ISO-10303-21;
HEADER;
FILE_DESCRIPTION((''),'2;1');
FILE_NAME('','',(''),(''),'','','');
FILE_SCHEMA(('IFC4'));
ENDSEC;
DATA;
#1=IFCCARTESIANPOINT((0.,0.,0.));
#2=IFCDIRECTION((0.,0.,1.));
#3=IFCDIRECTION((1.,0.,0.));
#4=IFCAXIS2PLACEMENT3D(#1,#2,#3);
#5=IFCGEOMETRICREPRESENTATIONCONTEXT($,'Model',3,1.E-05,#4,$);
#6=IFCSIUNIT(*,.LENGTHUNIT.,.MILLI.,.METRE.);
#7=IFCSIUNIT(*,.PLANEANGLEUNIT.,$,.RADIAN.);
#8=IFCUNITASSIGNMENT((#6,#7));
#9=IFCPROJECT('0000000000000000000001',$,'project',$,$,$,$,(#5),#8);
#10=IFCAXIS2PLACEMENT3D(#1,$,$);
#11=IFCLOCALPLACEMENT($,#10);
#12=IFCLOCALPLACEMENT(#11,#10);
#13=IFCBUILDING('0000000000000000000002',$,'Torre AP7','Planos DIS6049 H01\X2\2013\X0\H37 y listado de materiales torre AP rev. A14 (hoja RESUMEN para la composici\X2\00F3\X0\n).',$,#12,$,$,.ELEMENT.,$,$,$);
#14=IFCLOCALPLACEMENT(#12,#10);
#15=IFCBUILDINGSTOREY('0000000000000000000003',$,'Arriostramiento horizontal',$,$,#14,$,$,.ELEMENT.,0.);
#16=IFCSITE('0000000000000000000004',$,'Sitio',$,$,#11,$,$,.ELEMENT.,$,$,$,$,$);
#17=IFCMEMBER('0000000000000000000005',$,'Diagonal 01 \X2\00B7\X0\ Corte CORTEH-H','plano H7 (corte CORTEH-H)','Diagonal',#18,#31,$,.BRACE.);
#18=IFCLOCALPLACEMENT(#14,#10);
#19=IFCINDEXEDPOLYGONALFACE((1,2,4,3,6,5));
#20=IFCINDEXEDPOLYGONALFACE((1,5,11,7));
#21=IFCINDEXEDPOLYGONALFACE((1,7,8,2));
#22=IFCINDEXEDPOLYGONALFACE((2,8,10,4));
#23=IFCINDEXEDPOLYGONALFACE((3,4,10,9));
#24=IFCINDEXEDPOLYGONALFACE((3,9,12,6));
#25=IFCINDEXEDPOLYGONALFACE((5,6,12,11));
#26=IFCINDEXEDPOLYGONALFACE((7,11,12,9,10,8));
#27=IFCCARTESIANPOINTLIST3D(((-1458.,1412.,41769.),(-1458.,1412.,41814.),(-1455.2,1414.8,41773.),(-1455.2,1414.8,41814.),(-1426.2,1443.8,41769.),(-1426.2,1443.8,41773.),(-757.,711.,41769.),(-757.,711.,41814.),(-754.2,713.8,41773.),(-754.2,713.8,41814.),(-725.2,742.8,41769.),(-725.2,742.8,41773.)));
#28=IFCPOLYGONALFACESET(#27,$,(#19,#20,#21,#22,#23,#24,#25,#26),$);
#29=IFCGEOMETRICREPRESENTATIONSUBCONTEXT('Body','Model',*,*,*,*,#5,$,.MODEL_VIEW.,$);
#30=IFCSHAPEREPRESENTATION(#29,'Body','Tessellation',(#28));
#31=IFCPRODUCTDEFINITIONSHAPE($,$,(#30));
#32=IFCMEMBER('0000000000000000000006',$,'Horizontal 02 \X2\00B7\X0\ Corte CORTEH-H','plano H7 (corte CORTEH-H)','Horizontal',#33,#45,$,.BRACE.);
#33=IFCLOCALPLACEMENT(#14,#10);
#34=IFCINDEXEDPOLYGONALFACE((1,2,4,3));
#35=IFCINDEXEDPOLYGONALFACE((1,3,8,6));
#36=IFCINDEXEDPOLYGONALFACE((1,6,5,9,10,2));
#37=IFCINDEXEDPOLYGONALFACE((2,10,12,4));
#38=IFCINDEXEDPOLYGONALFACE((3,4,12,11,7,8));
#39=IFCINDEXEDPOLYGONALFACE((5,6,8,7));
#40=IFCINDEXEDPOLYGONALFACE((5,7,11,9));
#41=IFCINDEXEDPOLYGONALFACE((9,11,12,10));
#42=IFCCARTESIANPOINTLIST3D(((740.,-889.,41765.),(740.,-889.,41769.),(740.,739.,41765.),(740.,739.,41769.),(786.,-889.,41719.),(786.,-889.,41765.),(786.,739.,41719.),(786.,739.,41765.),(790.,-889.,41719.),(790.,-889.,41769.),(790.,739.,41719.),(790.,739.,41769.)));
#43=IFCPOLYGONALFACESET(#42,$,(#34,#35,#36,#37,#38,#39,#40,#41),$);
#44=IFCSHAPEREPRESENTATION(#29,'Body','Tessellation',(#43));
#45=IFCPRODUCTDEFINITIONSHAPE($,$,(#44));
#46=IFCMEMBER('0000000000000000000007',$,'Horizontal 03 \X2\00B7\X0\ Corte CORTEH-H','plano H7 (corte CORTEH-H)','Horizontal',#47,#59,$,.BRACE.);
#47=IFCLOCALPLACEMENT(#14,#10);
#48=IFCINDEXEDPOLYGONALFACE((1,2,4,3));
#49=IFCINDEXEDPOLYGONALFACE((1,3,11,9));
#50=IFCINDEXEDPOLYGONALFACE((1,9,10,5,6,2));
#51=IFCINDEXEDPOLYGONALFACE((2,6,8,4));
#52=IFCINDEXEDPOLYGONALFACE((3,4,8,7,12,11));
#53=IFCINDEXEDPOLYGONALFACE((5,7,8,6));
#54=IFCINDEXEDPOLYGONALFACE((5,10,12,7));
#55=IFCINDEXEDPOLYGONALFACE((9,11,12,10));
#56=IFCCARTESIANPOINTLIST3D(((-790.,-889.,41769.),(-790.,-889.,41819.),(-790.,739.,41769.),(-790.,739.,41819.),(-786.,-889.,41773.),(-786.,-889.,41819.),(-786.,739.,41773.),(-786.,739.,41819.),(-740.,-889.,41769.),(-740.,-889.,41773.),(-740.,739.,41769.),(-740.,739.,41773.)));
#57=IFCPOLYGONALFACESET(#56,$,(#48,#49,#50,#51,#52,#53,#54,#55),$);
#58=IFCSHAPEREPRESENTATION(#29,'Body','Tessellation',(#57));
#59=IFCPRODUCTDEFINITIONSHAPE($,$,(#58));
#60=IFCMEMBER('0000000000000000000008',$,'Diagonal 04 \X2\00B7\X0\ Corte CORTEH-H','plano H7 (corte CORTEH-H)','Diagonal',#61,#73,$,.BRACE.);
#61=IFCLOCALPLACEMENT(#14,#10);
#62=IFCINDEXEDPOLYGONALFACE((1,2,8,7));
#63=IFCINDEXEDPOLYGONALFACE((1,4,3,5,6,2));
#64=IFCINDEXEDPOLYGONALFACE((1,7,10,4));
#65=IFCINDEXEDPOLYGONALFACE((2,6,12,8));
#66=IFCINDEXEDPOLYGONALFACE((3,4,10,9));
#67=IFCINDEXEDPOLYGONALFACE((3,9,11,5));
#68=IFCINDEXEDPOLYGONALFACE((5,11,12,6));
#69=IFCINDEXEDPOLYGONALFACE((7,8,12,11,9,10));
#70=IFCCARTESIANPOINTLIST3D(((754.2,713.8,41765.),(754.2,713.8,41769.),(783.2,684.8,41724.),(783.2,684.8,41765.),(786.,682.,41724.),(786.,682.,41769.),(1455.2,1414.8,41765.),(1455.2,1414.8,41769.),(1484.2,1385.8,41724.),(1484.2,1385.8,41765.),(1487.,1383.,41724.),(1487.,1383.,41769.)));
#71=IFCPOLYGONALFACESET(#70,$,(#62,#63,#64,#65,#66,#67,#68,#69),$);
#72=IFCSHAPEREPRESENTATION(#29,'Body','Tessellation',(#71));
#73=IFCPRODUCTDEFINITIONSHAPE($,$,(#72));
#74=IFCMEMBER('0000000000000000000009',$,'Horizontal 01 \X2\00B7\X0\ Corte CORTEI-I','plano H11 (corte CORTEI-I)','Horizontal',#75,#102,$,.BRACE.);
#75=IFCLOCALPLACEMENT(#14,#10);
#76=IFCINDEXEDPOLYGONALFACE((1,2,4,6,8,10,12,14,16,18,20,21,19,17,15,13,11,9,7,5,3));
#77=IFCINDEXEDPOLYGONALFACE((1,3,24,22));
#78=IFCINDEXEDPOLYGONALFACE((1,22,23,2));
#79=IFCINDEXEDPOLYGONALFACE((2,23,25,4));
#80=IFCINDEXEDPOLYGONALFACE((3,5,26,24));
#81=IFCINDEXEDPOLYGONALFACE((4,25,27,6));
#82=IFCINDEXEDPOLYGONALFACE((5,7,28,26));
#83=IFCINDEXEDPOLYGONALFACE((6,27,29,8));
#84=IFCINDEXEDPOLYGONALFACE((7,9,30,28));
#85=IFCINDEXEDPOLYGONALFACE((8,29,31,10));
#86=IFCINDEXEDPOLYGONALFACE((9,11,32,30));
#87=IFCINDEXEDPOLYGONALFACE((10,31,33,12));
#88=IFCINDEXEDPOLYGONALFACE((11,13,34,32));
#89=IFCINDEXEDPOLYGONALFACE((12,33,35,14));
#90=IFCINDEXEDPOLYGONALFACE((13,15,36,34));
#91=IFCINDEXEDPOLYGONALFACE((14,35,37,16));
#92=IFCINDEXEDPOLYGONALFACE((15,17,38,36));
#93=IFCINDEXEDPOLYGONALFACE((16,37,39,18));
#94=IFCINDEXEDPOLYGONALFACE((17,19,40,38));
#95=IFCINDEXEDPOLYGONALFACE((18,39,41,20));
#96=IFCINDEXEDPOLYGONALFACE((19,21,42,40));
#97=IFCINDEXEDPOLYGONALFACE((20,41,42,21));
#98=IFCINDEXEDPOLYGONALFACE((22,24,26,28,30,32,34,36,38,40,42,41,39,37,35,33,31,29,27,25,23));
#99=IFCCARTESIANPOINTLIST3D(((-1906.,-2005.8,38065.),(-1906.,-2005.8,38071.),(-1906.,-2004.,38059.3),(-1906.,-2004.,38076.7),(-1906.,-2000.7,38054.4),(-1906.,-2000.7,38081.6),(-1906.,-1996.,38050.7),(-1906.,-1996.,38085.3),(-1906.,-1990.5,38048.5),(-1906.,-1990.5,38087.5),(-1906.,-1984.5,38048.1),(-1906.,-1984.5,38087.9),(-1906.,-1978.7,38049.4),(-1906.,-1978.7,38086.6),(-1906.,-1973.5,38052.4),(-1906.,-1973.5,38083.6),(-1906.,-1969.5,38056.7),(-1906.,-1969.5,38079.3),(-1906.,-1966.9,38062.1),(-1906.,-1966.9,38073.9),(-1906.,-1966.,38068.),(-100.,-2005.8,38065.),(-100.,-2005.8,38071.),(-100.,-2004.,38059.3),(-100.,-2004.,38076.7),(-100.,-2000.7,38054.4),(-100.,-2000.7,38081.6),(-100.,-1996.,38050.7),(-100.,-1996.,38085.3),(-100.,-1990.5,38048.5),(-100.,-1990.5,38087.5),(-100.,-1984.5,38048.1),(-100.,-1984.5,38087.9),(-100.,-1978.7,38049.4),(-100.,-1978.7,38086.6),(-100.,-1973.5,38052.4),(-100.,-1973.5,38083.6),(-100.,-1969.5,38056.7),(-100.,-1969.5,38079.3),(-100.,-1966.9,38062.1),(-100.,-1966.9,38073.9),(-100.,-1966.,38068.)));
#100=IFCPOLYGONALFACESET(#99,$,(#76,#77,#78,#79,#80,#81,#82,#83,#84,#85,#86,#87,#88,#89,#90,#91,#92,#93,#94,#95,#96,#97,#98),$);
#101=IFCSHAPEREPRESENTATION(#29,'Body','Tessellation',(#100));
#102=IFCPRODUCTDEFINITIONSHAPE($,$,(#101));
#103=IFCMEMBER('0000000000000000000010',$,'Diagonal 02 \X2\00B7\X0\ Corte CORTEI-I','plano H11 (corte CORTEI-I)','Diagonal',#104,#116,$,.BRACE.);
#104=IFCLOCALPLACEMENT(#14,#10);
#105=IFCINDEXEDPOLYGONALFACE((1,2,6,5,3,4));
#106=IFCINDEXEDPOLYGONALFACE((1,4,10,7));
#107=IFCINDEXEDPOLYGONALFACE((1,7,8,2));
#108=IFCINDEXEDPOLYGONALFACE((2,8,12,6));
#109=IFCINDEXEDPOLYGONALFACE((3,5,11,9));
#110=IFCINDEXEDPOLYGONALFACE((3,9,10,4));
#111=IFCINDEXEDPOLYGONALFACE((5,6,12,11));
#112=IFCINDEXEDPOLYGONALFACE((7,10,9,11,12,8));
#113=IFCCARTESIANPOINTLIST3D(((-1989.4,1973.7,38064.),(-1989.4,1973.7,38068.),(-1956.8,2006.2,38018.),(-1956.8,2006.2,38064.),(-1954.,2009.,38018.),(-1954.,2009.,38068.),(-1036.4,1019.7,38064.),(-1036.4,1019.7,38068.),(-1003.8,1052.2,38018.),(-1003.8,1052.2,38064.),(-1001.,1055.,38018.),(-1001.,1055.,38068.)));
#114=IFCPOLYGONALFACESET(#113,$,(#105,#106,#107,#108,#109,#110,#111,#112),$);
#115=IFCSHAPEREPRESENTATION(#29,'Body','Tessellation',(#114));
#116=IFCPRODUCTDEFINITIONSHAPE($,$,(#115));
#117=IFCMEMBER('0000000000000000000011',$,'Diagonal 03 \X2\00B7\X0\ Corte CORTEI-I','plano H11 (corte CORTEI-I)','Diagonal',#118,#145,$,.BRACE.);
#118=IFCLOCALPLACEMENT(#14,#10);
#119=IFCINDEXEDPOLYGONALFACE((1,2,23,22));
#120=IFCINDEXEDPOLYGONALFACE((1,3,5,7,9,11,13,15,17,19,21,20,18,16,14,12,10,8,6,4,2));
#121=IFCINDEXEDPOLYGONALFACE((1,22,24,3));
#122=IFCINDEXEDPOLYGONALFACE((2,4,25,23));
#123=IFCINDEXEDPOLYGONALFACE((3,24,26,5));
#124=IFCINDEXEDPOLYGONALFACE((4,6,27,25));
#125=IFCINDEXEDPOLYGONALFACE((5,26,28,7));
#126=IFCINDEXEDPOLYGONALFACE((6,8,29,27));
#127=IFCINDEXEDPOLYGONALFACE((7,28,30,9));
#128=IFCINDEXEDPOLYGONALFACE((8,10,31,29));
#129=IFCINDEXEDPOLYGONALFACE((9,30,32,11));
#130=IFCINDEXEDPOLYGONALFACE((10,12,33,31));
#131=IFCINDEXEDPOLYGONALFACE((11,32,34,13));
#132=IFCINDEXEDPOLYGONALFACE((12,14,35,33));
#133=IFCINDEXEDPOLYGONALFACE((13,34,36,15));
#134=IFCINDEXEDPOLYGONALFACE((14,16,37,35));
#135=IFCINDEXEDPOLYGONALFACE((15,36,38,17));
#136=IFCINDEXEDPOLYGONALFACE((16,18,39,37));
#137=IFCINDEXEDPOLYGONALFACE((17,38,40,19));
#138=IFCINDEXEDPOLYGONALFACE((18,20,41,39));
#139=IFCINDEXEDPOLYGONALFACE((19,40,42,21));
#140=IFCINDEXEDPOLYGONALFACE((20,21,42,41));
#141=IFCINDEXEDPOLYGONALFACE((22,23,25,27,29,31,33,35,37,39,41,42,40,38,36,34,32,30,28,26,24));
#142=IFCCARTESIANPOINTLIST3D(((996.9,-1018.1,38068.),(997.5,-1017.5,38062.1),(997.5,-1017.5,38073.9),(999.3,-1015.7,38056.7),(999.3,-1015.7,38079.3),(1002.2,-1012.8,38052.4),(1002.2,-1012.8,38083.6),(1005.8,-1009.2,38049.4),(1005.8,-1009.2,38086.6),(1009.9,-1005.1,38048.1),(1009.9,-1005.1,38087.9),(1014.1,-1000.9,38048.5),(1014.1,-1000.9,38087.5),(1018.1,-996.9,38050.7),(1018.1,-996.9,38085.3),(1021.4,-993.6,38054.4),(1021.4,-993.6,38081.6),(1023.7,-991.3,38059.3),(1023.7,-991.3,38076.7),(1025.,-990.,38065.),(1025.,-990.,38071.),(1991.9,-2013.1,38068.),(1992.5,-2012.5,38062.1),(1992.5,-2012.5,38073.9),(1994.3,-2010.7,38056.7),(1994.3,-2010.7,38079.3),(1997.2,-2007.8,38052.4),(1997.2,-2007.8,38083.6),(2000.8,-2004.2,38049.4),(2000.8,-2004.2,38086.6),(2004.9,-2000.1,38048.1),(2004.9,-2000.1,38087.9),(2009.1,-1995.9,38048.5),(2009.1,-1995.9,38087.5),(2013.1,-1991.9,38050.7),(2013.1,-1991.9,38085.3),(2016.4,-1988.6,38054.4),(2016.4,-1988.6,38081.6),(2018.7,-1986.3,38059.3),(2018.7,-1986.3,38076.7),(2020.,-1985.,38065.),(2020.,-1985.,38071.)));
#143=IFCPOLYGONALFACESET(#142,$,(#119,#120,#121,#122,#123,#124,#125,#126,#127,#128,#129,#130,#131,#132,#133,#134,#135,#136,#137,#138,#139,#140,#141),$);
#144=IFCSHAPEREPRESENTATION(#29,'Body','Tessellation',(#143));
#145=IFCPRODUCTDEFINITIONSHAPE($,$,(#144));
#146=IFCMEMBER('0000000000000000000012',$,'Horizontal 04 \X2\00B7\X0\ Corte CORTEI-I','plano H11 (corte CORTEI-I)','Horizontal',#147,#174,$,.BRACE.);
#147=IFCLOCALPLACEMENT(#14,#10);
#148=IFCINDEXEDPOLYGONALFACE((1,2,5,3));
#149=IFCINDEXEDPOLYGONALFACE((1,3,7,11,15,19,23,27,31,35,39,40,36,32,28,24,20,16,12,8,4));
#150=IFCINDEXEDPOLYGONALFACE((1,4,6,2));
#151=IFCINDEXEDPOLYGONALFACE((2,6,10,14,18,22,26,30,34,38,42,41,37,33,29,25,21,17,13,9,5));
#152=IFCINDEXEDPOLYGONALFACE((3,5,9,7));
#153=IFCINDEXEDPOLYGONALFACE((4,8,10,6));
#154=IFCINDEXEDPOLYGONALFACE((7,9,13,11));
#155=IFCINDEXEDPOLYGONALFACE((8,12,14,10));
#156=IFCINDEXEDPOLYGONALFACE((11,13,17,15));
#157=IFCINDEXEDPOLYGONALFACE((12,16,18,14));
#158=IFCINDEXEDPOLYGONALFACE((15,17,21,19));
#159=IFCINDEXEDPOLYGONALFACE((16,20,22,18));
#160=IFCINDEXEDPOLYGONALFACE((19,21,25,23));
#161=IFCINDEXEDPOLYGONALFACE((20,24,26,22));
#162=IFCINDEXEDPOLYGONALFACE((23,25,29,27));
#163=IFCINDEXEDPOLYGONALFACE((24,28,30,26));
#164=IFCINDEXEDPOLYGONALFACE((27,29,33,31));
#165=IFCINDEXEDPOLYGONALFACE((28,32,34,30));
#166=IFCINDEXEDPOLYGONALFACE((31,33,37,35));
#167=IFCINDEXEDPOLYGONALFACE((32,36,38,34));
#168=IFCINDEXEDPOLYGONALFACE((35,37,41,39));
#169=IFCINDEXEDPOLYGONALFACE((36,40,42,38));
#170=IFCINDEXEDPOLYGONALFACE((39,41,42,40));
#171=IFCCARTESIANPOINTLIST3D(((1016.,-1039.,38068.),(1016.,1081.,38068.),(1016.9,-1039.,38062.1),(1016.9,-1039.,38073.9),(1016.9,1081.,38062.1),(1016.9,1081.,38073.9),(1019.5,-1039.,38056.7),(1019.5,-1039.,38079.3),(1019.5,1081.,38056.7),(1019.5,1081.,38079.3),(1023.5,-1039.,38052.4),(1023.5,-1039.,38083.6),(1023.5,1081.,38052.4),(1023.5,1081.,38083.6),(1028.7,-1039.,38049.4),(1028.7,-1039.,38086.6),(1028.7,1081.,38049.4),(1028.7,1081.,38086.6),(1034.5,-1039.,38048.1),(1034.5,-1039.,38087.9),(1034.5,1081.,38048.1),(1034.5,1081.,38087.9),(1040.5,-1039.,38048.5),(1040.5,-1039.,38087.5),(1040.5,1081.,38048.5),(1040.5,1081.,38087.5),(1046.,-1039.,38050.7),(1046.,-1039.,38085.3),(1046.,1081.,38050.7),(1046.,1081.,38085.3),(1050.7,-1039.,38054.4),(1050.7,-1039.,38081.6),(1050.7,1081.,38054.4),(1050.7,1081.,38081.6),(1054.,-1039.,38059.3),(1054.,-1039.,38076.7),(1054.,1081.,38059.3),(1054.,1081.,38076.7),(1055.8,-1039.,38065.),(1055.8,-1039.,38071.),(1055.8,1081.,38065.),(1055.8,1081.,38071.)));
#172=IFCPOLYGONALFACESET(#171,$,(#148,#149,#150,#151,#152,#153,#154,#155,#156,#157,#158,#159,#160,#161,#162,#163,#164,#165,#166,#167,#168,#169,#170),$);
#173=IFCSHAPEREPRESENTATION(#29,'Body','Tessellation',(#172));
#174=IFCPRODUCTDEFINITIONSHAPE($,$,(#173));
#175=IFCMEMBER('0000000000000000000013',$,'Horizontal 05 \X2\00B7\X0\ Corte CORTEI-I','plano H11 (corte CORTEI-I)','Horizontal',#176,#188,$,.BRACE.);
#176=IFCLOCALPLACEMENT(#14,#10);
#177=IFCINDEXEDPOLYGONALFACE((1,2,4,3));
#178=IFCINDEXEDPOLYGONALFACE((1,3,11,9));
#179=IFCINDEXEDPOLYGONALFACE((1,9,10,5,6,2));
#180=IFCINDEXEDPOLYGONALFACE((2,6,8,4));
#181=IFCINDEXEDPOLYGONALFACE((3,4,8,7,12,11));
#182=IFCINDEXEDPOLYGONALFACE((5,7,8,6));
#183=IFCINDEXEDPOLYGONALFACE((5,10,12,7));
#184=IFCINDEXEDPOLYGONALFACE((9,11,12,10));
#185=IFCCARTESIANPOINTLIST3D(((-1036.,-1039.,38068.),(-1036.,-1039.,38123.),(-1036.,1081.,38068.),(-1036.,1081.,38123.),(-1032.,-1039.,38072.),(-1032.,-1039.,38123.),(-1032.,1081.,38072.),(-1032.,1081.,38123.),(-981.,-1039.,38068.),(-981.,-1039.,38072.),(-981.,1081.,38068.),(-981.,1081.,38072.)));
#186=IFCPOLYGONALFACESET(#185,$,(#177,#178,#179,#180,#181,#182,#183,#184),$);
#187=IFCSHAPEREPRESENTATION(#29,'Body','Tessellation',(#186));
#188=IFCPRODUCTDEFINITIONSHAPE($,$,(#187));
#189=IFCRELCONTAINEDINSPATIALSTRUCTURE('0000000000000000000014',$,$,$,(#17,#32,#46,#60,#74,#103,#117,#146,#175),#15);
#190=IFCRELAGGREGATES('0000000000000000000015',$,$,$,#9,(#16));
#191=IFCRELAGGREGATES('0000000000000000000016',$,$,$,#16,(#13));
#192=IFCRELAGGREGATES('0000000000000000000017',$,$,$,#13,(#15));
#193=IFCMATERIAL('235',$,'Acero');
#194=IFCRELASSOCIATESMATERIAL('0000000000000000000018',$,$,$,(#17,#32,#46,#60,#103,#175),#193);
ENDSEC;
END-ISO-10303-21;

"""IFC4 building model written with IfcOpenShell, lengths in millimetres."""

from ifc_helpers import new_model, si_unit, frame, frame_2d, origin, origin_with_axes, place, context, subcontext, project, spatial, circle, l_section, extrude, material, element, save


model = new_model("IFC4")

# Units and contexts
model_context = context("Model", 3, precision=1e-05, world=origin_with_axes())
body_context = subcontext(model_context, "Body", "Model", "MODEL_VIEW")
ifc_project = project(units=[si_unit("LENGTHUNIT", "METRE", prefix="MILLI"), si_unit("PLANEANGLEUNIT", "RADIAN")], contexts=[model_context])

# Site, building, storey
site_placement = place(None, origin())
site = spatial("IfcSite", under=ifc_project, at=site_placement, Name="Sitio", CompositionType="ELEMENT")
building_placement = place(site_placement, origin())
building = spatial("IfcBuilding", under=site, at=building_placement, Name="Torre AP7", Description="Planos DIS6049 H01–H37 y listado de materiales torre AP rev. A14 (hoja RESUMEN para la composición).", CompositionType="ELEMENT")
storey_placement = place(building_placement, origin())
storey = spatial("IfcBuildingStorey", under=building, at=storey_placement, Name="Arriostramiento horizontal", CompositionType="ELEMENT", Elevation=0.0)

# Members
ifc_material = material(Name="235", Category="Acero")
member_1_placement = place(storey_placement, frame((-1458.0, 1412.0, 41769.0), z_axis=(0.707107, -0.707107, 0.0), x_axis=(0.707107, 0.707107, 0.0)))
element("IfcMember", 1, at=member_1_placement, inside=storey, material=ifc_material, Name="Diagonal 01 · Corte CORTEH-H", Description="plano H7 (corte CORTEH-H)", ObjectType="Diagonal", PredefinedType="BRACE", context=body_context, shape_type="SweptSolid", body=[
    extrude(l_section(Depth=45.0, Width=45.0, Thickness=4.0, at=frame_2d((22.5, 22.5))), None, (0.0, 0.0, 1.0), 991.4),
])
for number, where, z_axis, x_axis, name in (
    (2, (790.0, 739.0, 41769.0), (0.0, -1.0, 0.0), (-1.0, 0.0, 0.0), "Horizontal 02 · Corte CORTEH-H"),
    (3, (-790.0, 739.0, 41769.0), (0.0, -1.0, 0.0), (1.0, 0.0, 0.0), "Horizontal 03 · Corte CORTEH-H"),
):
    element("IfcMember", number, at=place(storey_placement, frame(where, z_axis=z_axis, x_axis=x_axis)), inside=storey, material=ifc_material, Name=name, Description="plano H7 (corte CORTEH-H)", ObjectType="Horizontal", PredefinedType="BRACE", context=body_context, shape_type="SweptSolid", body=[
        extrude(l_section(Depth=50.0, Width=50.0, Thickness=4.0, at=frame_2d((25.0, 25.0))), None, (0.0, 0.0, 1.0), 1628.0),
    ])
member_2_placement = place(storey_placement, frame((1487.0, 1383.0, 41769.0), z_axis=(-0.707107, -0.707107, 0.0), x_axis=(-0.707107, 0.707107, 0.0)))
element("IfcMember", 4, at=member_2_placement, inside=storey, material=ifc_material, Name="Diagonal 04 · Corte CORTEH-H", Description="plano H7 (corte CORTEH-H)", ObjectType="Diagonal", PredefinedType="BRACE", context=body_context, shape_type="SweptSolid", body=[
    extrude(l_section(Depth=45.0, Width=45.0, Thickness=4.0, at=frame_2d((22.5, 22.5))), None, (0.0, 0.0, 1.0), 991.4),
])
member_3_placement = place(storey_placement, frame((-1906.0, -1986.0, 38068.0), z_axis=(1.0, 0.0, 0.0), x_axis=(0.0, 1.0, 0.0)))
element("IfcMember", 5, at=member_3_placement, inside=storey, Name="Horizontal 01 · Corte CORTEI-I", Description="plano H11 (corte CORTEI-I)", ObjectType="Horizontal", PredefinedType="BRACE", context=body_context, shape_type="SweptSolid", body=[
    extrude(circle(Radius=20.0), None, (0.0, 0.0, 1.0), 1806.0),
])
member_4_placement = place(storey_placement, frame((-1954.0, 2009.0, 38068.0), z_axis=(0.706736, -0.707477, 0.0), x_axis=(-0.707477, -0.706736, 0.0)))
element("IfcMember", 6, at=member_4_placement, inside=storey, material=ifc_material, Name="Diagonal 02 · Corte CORTEI-I", Description="plano H11 (corte CORTEI-I)", ObjectType="Diagonal", PredefinedType="BRACE", context=body_context, shape_type="SweptSolid", body=[
    extrude(l_section(Depth=50.0, Width=50.0, Thickness=4.0, at=frame_2d((25.0, 25.0))), None, (0.0, 0.0, 1.0), 1348.5),
])
member_5_placement = place(storey_placement, frame((1011.0, -1004.0, 38068.0), z_axis=(0.707107, -0.707107, 0.0), x_axis=(-0.707107, -0.707107, 0.0)))
element("IfcMember", 7, at=member_5_placement, inside=storey, Name="Diagonal 03 · Corte CORTEI-I", Description="plano H11 (corte CORTEI-I)", ObjectType="Diagonal", PredefinedType="BRACE", context=body_context, shape_type="SweptSolid", body=[
    extrude(circle(Radius=20.0), None, (0.0, 0.0, 1.0), 1407.1),
])
member_6_placement = place(storey_placement, frame((1036.0, 1081.0, 38068.0), z_axis=(0.0, -1.0, 0.0), x_axis=(-1.0, 0.0, 0.0)))
element("IfcMember", 8, at=member_6_placement, inside=storey, Name="Horizontal 04 · Corte CORTEI-I", Description="plano H11 (corte CORTEI-I)", ObjectType="Horizontal", PredefinedType="BRACE", context=body_context, shape_type="SweptSolid", body=[
    extrude(circle(Radius=20.0), None, (0.0, 0.0, 1.0), 2120.0),
])
member_7_placement = place(storey_placement, frame((-1036.0, 1081.0, 38068.0), z_axis=(0.0, -1.0, 0.0), x_axis=(1.0, 0.0, 0.0)))
element("IfcMember", 9, at=member_7_placement, inside=storey, material=ifc_material, Name="Horizontal 05 · Corte CORTEI-I", Description="plano H11 (corte CORTEI-I)", ObjectType="Horizontal", PredefinedType="BRACE", context=body_context, shape_type="SweptSolid", body=[
    extrude(l_section(Depth=55.0, Width=55.0, Thickness=4.0, at=frame_2d((27.5, 27.5))), None, (0.0, 0.0, 1.0), 2120.0),
])

save(model, "model.ifc")
